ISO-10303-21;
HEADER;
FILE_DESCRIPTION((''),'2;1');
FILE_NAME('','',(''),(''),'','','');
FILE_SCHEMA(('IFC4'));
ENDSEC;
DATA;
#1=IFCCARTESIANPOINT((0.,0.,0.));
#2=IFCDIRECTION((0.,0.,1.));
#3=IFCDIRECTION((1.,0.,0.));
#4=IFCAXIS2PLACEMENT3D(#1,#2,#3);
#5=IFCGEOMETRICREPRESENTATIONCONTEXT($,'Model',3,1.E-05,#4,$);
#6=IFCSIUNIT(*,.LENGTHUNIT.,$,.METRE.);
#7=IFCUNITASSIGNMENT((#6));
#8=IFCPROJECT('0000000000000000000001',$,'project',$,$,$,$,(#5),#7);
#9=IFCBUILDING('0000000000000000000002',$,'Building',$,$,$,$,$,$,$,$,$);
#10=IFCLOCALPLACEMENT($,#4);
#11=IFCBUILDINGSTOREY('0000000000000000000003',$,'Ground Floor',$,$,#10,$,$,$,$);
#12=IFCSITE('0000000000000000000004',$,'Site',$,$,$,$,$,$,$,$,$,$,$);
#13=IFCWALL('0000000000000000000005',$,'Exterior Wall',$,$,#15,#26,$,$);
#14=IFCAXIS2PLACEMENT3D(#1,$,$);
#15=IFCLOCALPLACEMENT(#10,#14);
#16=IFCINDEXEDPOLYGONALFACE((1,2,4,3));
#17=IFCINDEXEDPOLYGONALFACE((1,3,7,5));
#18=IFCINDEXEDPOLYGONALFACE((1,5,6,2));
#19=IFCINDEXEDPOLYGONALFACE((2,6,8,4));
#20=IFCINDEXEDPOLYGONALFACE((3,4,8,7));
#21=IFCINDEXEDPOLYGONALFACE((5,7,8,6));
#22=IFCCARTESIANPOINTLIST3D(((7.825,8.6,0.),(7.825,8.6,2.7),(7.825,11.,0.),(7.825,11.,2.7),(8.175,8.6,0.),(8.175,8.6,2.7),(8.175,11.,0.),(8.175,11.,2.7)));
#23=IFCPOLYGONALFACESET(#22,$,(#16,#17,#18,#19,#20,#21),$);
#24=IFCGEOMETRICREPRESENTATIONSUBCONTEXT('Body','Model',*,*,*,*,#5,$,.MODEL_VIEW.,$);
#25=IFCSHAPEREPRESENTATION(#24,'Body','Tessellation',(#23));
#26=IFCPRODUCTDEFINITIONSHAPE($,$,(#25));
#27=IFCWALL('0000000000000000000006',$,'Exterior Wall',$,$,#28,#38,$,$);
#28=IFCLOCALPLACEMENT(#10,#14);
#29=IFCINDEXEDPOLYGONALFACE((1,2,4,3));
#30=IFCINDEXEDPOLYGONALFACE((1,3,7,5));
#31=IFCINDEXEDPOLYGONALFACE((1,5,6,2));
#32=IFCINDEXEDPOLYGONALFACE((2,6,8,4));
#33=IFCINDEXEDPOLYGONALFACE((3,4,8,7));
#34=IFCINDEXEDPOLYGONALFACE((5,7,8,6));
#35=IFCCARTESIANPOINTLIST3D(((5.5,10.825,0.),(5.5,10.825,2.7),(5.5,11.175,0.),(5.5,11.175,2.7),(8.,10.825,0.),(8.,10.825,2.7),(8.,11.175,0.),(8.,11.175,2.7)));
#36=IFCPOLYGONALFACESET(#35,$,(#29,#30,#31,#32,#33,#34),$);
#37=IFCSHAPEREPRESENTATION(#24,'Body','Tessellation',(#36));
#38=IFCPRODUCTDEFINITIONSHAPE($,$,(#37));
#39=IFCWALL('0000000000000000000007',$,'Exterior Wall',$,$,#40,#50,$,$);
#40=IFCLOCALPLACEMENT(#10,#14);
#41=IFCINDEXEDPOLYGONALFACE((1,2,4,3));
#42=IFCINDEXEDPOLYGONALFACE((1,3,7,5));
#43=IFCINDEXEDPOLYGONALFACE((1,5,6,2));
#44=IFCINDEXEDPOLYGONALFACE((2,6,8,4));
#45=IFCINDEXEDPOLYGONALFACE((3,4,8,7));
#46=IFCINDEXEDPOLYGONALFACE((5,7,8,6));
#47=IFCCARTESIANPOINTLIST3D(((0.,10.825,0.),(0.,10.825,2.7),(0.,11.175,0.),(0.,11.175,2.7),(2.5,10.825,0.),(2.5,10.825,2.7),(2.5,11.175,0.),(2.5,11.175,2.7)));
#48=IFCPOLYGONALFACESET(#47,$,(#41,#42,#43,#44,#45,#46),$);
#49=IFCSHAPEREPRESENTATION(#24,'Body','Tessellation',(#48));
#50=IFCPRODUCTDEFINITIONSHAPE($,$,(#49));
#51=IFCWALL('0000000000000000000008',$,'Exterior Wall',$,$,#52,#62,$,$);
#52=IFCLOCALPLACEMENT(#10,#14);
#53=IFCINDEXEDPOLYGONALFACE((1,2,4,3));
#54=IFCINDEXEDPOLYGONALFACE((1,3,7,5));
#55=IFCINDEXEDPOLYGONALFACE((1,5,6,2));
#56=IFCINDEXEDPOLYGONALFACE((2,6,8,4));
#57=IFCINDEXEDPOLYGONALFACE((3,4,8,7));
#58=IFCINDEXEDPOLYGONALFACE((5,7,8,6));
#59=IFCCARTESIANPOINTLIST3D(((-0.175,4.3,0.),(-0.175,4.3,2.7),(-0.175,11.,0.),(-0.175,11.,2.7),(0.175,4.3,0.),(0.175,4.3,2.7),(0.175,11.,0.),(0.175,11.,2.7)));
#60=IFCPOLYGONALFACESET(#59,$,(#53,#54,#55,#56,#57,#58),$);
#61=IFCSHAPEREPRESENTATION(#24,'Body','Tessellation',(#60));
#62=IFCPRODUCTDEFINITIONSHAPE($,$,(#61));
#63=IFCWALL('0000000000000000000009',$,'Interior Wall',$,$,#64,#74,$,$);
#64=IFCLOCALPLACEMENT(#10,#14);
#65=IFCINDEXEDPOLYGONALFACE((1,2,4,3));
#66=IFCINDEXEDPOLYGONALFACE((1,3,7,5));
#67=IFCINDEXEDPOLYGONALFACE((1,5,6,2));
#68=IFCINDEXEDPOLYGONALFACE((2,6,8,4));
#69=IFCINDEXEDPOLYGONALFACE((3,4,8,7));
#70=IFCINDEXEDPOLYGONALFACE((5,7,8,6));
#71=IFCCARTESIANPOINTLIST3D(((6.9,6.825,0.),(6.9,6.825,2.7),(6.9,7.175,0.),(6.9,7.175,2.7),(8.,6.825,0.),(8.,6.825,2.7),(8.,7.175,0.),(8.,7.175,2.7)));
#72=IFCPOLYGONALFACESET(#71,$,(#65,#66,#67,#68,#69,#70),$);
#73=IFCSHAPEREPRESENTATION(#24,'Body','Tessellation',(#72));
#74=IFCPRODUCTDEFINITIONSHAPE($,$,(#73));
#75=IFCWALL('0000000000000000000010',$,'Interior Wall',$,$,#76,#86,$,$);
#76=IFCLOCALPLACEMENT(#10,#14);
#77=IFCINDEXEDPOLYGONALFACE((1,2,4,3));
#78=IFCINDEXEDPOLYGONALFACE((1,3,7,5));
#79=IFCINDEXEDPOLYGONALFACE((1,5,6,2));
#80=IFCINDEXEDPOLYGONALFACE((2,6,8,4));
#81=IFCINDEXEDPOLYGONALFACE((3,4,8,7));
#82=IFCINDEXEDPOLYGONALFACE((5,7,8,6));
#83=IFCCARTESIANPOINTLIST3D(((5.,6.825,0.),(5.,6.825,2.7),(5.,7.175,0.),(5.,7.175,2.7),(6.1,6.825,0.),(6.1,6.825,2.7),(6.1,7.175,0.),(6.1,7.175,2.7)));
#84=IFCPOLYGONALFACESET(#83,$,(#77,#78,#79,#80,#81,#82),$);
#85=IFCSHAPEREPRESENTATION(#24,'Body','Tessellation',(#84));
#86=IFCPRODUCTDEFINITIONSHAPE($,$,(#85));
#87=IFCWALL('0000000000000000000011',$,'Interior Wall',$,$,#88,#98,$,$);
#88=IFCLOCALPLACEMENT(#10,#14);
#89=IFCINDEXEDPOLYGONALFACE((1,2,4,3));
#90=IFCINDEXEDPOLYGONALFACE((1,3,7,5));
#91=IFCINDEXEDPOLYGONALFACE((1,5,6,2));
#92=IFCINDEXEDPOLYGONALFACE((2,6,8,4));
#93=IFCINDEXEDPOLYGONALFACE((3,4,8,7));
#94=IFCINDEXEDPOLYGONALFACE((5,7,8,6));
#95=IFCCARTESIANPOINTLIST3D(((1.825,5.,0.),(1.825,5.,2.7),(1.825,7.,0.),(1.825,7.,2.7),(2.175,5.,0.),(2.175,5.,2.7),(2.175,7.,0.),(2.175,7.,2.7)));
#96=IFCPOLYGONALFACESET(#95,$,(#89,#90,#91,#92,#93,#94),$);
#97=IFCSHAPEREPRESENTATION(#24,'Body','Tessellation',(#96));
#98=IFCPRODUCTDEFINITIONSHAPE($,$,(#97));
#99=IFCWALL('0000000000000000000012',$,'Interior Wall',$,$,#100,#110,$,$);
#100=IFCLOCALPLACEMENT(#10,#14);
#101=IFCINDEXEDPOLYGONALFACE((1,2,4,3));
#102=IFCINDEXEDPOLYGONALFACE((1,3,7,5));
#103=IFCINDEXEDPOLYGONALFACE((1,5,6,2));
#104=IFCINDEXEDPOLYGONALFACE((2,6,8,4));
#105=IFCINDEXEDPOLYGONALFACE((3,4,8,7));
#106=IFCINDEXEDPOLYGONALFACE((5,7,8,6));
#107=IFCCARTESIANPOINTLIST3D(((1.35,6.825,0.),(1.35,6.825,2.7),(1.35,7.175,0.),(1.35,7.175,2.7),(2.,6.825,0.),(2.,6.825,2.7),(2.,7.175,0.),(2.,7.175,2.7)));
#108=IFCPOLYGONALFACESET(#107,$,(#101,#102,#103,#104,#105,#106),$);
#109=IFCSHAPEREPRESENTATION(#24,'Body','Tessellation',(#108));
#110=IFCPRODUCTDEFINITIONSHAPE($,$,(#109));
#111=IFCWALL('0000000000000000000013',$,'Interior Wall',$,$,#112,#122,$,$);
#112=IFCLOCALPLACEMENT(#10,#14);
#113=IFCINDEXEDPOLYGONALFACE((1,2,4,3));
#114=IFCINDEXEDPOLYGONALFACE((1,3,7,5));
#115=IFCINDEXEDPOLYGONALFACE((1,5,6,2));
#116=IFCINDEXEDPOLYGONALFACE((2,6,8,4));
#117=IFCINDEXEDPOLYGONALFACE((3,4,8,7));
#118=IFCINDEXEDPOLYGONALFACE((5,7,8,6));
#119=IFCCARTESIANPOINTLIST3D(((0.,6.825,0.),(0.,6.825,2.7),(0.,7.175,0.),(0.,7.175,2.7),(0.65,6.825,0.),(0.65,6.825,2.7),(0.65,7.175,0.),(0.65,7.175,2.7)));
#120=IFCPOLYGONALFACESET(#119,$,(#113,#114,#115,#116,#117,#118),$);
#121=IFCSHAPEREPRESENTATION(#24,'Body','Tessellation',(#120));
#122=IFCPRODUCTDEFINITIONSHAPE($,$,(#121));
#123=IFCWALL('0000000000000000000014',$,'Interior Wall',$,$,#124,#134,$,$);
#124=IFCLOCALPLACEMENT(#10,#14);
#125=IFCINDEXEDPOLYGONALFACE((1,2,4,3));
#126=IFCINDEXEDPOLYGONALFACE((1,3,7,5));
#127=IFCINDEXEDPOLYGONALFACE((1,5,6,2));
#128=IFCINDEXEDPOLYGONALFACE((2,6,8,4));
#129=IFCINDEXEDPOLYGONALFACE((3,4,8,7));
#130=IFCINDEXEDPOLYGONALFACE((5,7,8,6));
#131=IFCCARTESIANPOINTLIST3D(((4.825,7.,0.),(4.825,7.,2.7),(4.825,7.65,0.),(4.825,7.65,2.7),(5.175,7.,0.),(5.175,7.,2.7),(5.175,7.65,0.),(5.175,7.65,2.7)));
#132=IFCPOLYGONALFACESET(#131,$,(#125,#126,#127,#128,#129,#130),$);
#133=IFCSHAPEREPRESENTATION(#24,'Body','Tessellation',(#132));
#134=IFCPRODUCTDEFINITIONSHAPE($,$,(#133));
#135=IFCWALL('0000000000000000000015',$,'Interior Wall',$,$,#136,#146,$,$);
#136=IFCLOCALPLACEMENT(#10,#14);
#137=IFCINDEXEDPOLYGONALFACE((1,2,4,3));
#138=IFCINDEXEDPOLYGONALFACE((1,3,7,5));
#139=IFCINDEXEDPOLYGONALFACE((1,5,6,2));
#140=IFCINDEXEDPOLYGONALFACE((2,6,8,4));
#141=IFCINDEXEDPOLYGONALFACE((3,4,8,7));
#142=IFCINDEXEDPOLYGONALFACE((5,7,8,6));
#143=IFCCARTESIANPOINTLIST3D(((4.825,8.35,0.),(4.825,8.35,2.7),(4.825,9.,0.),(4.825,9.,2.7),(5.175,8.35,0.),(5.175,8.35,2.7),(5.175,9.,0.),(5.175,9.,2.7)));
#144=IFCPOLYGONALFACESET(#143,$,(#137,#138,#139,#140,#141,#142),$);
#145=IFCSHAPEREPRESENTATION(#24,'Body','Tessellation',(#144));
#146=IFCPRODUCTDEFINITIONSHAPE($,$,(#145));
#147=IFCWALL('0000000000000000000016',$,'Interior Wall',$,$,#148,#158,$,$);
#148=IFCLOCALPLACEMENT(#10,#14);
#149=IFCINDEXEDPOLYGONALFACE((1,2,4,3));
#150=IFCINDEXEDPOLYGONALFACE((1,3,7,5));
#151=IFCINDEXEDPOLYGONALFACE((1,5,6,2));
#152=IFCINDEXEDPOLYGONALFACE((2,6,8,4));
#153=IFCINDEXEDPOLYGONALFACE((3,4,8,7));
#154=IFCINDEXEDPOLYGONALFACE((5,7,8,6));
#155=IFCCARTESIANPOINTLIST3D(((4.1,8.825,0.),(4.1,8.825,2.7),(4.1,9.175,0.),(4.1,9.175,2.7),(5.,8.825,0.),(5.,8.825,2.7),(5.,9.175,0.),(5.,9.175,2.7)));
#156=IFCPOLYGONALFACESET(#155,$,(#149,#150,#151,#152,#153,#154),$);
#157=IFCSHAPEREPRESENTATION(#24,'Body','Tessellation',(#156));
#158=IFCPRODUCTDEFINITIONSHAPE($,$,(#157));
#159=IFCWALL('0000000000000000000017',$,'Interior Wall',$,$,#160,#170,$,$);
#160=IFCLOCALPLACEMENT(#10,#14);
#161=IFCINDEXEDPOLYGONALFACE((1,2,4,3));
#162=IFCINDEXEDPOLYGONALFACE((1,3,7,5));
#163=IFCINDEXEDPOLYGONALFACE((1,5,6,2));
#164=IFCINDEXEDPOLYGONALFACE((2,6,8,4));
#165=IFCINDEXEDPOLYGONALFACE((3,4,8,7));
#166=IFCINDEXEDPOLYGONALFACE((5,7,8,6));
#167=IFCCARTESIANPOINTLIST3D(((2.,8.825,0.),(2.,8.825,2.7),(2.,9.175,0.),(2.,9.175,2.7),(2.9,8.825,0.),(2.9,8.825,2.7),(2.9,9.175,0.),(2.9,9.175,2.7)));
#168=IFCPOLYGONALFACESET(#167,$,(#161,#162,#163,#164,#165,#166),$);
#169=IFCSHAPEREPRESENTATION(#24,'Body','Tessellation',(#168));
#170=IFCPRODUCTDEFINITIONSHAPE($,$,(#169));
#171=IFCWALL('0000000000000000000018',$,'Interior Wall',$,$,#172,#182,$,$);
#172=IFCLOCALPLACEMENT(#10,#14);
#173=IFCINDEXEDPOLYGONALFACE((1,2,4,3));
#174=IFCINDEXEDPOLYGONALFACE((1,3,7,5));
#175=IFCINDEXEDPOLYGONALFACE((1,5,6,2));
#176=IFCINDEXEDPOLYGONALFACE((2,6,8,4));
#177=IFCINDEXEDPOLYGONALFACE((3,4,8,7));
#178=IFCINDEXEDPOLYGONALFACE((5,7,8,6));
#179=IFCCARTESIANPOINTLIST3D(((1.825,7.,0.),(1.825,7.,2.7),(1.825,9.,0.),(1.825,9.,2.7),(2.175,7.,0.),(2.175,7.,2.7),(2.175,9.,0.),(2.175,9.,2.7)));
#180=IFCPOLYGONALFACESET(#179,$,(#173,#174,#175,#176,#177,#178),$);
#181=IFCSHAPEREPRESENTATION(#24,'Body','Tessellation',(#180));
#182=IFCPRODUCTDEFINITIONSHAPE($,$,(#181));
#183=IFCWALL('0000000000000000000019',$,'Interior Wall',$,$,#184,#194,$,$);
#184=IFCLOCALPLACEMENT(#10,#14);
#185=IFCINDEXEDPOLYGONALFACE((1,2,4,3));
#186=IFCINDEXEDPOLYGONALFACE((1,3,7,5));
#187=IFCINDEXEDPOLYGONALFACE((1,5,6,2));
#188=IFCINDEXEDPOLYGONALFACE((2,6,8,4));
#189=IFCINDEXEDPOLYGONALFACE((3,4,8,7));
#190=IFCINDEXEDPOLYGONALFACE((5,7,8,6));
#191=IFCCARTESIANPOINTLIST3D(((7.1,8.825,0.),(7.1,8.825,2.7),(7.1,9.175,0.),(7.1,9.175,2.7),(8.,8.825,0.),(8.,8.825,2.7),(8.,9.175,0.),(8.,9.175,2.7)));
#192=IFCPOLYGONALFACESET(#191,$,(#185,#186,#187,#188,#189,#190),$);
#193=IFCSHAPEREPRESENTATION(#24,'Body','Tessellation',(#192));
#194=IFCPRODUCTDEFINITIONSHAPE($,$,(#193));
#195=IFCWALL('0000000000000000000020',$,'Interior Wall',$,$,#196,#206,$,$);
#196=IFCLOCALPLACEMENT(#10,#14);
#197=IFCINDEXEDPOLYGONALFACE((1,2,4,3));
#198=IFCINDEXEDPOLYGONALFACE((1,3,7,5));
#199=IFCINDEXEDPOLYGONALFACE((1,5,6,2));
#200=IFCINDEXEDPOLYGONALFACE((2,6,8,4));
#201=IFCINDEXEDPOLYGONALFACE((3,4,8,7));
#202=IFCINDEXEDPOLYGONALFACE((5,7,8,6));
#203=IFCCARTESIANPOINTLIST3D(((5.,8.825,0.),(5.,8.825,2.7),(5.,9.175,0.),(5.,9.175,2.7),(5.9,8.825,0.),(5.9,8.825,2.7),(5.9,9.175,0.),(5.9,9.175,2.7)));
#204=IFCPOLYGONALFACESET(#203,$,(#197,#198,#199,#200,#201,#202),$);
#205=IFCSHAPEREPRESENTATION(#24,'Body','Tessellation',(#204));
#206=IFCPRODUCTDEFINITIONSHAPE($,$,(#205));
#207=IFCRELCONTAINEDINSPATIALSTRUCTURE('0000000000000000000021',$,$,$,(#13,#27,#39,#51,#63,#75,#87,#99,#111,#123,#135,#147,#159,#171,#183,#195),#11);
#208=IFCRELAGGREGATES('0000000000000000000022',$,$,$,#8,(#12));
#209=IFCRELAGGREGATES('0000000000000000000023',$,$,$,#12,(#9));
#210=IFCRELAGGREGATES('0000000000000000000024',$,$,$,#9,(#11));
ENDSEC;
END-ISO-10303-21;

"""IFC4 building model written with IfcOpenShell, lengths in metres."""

from ifc_helpers import new_model, si_unit, frame, origin_with_axes, place, context, subcontext, project, spatial, indexed_curve, outline, extrude, element, save


model = new_model("IFC4")

# Units and contexts
model_context = context("Model", 3, precision=1e-05, world=origin_with_axes())
body_context = subcontext(model_context, "Body", "Model", "MODEL_VIEW")
ifc_project = project(units=[si_unit("LENGTHUNIT", "METRE")], contexts=[model_context])

# Site, building, storey
site = spatial("IfcSite", under=ifc_project, Name="Site")
building = spatial("IfcBuilding", under=site, Name="Building")
storey_placement = place(None, origin_with_axes())
storey = spatial("IfcBuildingStorey", under=building, at=storey_placement, Name="Ground Floor")

# Walls
wall_1_placement = place(storey_placement, frame((8.0, 8.6, 0.0), z_axis=(0.0, 0.0, 1.0), x_axis=(0.0, 1.0, 0.0)))
element("IfcWall", 1, at=wall_1_placement, inside=storey, Name="Exterior Wall", context=body_context, shape_type="SweptSolid", body=[
    extrude(outline(indexed_curve([(0.0, 0.0), (0.0, 0.35), (2.4, 0.35), (2.4, 0.0), (0.0, 0.0)], self_intersect=False)), frame((0.0, -0.175, 0.0), z_axis=(0.0, 0.0, 1.0), x_axis=(1.0, 0.0, 0.0)), (0.0, 0.0, 1.0), 2.7),
])
for number, where, z_axis, x_axis, name in (
    (2, (8.0, 11.0, 0.0), (0.0, 0.0, 1.0), (-1.0, 0.0, 0.0), "Exterior Wall"),
    (3, (2.5, 11.0, 0.0), (0.0, 0.0, 1.0), (-1.0, 0.0, 0.0), "Exterior Wall"),
):
    element("IfcWall", number, at=place(storey_placement, frame(where, z_axis=z_axis, x_axis=x_axis)), inside=storey, Name=name, context=body_context, shape_type="SweptSolid", body=[
        extrude(outline(indexed_curve([(0.0, 0.0), (0.0, 0.35), (2.5, 0.35), (2.5, 0.0), (0.0, 0.0)], self_intersect=False)), frame((0.0, -0.175, 0.0), z_axis=(0.0, 0.0, 1.0), x_axis=(1.0, 0.0, 0.0)), (0.0, 0.0, 1.0), 2.7),
    ])
wall_2_placement = place(storey_placement, frame((0.0, 11.0, 0.0), z_axis=(0.0, 0.0, 1.0), x_axis=(0.0, -1.0, 0.0)))
element("IfcWall", 4, at=wall_2_placement, inside=storey, Name="Exterior Wall", context=body_context, shape_type="SweptSolid", body=[
    extrude(outline(indexed_curve([(0.0, 0.0), (0.0, 0.35), (6.7, 0.35), (6.7, 0.0), (0.0, 0.0)], self_intersect=False)), frame((0.0, -0.175, 0.0), z_axis=(0.0, 0.0, 1.0), x_axis=(1.0, 0.0, 0.0)), (0.0, 0.0, 1.0), 2.7),
])
for number, where, z_axis, x_axis, name in (
    (5, (8.0, 7.0, 0.0), (0.0, 0.0, 1.0), (-1.0, 0.0, 0.0), "Interior Wall"),
    (6, (6.1, 7.0, 0.0), (0.0, 0.0, 1.0), (-1.0, 0.0, 0.0), "Interior Wall"),
):
    element("IfcWall", number, at=place(storey_placement, frame(where, z_axis=z_axis, x_axis=x_axis)), inside=storey, Name=name, context=body_context, shape_type="SweptSolid", body=[
        extrude(outline(indexed_curve([(0.0, 0.0), (0.0, 0.35), (1.1, 0.35), (1.1, 0.0), (0.0, 0.0)], self_intersect=False)), frame((0.0, -0.175, 0.0), z_axis=(0.0, 0.0, 1.0), x_axis=(1.0, 0.0, 0.0)), (0.0, 0.0, 1.0), 2.7),
    ])
wall_3_placement = place(storey_placement, frame((2.0, 7.0, 0.0), z_axis=(0.0, 0.0, 1.0), x_axis=(0.0, -1.0, 0.0)))
element("IfcWall", 7, at=wall_3_placement, inside=storey, Name="Interior Wall", context=body_context, shape_type="SweptSolid", body=[
    extrude(outline(indexed_curve([(0.0, 0.0), (0.0, 0.35), (2.0, 0.35), (2.0, 0.0), (0.0, 0.0)], self_intersect=False)), frame((0.0, -0.175, 0.0), z_axis=(0.0, 0.0, 1.0), x_axis=(1.0, 0.0, 0.0)), (0.0, 0.0, 1.0), 2.7),
])
for number, where, z_axis, x_axis, name in (
    (8, (2.0, 7.0, 0.0), (0.0, 0.0, 1.0), (-1.0, 0.0, 0.0), "Interior Wall"),
    (9, (0.65, 7.0, 0.0), (0.0, 0.0, 1.0), (-1.0, 0.0, 0.0), "Interior Wall"),
):
    element("IfcWall", number, at=place(storey_placement, frame(where, z_axis=z_axis, x_axis=x_axis)), inside=storey, Name=name, context=body_context, shape_type="SweptSolid", body=[
        extrude(outline(indexed_curve([(0.0, 0.0), (0.0, 0.35), (0.65, 0.35), (0.65, 0.0), (0.0, 0.0)], self_intersect=False)), frame((0.0, -0.175, 0.0), z_axis=(0.0, 0.0, 1.0), x_axis=(1.0, 0.0, 0.0)), (0.0, 0.0, 1.0), 2.7),
    ])
for number, where, z_axis, x_axis, name in (
    (10, (5.0, 7.0, 0.0), (0.0, 0.0, 1.0), (0.0, 1.0, 0.0), "Interior Wall"),
    (11, (5.0, 8.35, 0.0), (0.0, 0.0, 1.0), (0.0, 1.0, 0.0), "Interior Wall"),
):
    element("IfcWall", number, at=place(storey_placement, frame(where, z_axis=z_axis, x_axis=x_axis)), inside=storey, Name=name, context=body_context, shape_type="SweptSolid", body=[
        extrude(outline(indexed_curve([(0.0, 0.0), (0.0, 0.35), (0.65, 0.35), (0.65, 0.0), (0.0, 0.0)], self_intersect=False)), frame((0.0, -0.175, 0.0), z_axis=(0.0, 0.0, 1.0), x_axis=(1.0, 0.0, 0.0)), (0.0, 0.0, 1.0), 2.7),
    ])
wall_4_placement = place(storey_placement, frame((5.0, 9.0, 0.0), z_axis=(0.0, 0.0, 1.0), x_axis=(-1.0, 0.0, 0.0)))
element("IfcWall", 12, at=wall_4_placement, inside=storey, Name="Interior Wall", context=body_context, shape_type="SweptSolid", body=[
    extrude(outline(indexed_curve([(0.0, 0.0), (0.0, 0.35), (0.9, 0.35), (0.9, 0.0), (0.0, 0.0)], self_intersect=False)), frame((0.0, -0.175, 0.0), z_axis=(0.0, 0.0, 1.0), x_axis=(1.0, 0.0, 0.0)), (0.0, 0.0, 1.0), 2.7),
])
wall_5_placement = place(storey_placement, frame((2.9, 9.0, 0.0), z_axis=(0.0, 0.0, 1.0), x_axis=(-1.0, 0.0, 0.0)))
element("IfcWall", 13, at=wall_5_placement, inside=storey, Name="Interior Wall", context=body_context, shape_type="SweptSolid", body=[
    extrude(outline(indexed_curve([(0.0, 0.0), (0.0, 0.35), (0.9, 0.35), (0.9, 0.0), (0.0, 0.0)], self_intersect=False)), frame((0.0, -0.175, 0.0), z_axis=(0.0, 0.0, 1.0), x_axis=(1.0, 0.0, 0.0)), (0.0, 0.0, 1.0), 2.7),
])
wall_6_placement = place(storey_placement, frame((2.0, 9.0, 0.0), z_axis=(0.0, 0.0, 1.0), x_axis=(0.0, -1.0, 0.0)))
element("IfcWall", 14, at=wall_6_placement, inside=storey, Name="Interior Wall", context=body_context, shape_type="SweptSolid", body=[
    extrude(outline(indexed_curve([(0.0, 0.0), (0.0, 0.35), (2.0, 0.35), (2.0, 0.0), (0.0, 0.0)], self_intersect=False)), frame((0.0, -0.175, 0.0), z_axis=(0.0, 0.0, 1.0), x_axis=(1.0, 0.0, 0.0)), (0.0, 0.0, 1.0), 2.7),
])
for number, where, z_axis, x_axis, name in (
    (15, (8.0, 9.0, 0.0), (0.0, 0.0, 1.0), (-1.0, 0.0, 0.0), "Interior Wall"),
    (16, (5.9, 9.0, 0.0), (0.0, 0.0, 1.0), (-1.0, 0.0, 0.0), "Interior Wall"),
):
    element("IfcWall", number, at=place(storey_placement, frame(where, z_axis=z_axis, x_axis=x_axis)), inside=storey, Name=name, context=body_context, shape_type="SweptSolid", body=[
        extrude(outline(indexed_curve([(0.0, 0.0), (0.0, 0.35), (0.9, 0.35), (0.9, 0.0), (0.0, 0.0)], self_intersect=False)), frame((0.0, -0.175, 0.0), z_axis=(0.0, 0.0, 1.0), x_axis=(1.0, 0.0, 0.0)), (0.0, 0.0, 1.0), 2.7),
    ])

save(model, "model.ifc")
